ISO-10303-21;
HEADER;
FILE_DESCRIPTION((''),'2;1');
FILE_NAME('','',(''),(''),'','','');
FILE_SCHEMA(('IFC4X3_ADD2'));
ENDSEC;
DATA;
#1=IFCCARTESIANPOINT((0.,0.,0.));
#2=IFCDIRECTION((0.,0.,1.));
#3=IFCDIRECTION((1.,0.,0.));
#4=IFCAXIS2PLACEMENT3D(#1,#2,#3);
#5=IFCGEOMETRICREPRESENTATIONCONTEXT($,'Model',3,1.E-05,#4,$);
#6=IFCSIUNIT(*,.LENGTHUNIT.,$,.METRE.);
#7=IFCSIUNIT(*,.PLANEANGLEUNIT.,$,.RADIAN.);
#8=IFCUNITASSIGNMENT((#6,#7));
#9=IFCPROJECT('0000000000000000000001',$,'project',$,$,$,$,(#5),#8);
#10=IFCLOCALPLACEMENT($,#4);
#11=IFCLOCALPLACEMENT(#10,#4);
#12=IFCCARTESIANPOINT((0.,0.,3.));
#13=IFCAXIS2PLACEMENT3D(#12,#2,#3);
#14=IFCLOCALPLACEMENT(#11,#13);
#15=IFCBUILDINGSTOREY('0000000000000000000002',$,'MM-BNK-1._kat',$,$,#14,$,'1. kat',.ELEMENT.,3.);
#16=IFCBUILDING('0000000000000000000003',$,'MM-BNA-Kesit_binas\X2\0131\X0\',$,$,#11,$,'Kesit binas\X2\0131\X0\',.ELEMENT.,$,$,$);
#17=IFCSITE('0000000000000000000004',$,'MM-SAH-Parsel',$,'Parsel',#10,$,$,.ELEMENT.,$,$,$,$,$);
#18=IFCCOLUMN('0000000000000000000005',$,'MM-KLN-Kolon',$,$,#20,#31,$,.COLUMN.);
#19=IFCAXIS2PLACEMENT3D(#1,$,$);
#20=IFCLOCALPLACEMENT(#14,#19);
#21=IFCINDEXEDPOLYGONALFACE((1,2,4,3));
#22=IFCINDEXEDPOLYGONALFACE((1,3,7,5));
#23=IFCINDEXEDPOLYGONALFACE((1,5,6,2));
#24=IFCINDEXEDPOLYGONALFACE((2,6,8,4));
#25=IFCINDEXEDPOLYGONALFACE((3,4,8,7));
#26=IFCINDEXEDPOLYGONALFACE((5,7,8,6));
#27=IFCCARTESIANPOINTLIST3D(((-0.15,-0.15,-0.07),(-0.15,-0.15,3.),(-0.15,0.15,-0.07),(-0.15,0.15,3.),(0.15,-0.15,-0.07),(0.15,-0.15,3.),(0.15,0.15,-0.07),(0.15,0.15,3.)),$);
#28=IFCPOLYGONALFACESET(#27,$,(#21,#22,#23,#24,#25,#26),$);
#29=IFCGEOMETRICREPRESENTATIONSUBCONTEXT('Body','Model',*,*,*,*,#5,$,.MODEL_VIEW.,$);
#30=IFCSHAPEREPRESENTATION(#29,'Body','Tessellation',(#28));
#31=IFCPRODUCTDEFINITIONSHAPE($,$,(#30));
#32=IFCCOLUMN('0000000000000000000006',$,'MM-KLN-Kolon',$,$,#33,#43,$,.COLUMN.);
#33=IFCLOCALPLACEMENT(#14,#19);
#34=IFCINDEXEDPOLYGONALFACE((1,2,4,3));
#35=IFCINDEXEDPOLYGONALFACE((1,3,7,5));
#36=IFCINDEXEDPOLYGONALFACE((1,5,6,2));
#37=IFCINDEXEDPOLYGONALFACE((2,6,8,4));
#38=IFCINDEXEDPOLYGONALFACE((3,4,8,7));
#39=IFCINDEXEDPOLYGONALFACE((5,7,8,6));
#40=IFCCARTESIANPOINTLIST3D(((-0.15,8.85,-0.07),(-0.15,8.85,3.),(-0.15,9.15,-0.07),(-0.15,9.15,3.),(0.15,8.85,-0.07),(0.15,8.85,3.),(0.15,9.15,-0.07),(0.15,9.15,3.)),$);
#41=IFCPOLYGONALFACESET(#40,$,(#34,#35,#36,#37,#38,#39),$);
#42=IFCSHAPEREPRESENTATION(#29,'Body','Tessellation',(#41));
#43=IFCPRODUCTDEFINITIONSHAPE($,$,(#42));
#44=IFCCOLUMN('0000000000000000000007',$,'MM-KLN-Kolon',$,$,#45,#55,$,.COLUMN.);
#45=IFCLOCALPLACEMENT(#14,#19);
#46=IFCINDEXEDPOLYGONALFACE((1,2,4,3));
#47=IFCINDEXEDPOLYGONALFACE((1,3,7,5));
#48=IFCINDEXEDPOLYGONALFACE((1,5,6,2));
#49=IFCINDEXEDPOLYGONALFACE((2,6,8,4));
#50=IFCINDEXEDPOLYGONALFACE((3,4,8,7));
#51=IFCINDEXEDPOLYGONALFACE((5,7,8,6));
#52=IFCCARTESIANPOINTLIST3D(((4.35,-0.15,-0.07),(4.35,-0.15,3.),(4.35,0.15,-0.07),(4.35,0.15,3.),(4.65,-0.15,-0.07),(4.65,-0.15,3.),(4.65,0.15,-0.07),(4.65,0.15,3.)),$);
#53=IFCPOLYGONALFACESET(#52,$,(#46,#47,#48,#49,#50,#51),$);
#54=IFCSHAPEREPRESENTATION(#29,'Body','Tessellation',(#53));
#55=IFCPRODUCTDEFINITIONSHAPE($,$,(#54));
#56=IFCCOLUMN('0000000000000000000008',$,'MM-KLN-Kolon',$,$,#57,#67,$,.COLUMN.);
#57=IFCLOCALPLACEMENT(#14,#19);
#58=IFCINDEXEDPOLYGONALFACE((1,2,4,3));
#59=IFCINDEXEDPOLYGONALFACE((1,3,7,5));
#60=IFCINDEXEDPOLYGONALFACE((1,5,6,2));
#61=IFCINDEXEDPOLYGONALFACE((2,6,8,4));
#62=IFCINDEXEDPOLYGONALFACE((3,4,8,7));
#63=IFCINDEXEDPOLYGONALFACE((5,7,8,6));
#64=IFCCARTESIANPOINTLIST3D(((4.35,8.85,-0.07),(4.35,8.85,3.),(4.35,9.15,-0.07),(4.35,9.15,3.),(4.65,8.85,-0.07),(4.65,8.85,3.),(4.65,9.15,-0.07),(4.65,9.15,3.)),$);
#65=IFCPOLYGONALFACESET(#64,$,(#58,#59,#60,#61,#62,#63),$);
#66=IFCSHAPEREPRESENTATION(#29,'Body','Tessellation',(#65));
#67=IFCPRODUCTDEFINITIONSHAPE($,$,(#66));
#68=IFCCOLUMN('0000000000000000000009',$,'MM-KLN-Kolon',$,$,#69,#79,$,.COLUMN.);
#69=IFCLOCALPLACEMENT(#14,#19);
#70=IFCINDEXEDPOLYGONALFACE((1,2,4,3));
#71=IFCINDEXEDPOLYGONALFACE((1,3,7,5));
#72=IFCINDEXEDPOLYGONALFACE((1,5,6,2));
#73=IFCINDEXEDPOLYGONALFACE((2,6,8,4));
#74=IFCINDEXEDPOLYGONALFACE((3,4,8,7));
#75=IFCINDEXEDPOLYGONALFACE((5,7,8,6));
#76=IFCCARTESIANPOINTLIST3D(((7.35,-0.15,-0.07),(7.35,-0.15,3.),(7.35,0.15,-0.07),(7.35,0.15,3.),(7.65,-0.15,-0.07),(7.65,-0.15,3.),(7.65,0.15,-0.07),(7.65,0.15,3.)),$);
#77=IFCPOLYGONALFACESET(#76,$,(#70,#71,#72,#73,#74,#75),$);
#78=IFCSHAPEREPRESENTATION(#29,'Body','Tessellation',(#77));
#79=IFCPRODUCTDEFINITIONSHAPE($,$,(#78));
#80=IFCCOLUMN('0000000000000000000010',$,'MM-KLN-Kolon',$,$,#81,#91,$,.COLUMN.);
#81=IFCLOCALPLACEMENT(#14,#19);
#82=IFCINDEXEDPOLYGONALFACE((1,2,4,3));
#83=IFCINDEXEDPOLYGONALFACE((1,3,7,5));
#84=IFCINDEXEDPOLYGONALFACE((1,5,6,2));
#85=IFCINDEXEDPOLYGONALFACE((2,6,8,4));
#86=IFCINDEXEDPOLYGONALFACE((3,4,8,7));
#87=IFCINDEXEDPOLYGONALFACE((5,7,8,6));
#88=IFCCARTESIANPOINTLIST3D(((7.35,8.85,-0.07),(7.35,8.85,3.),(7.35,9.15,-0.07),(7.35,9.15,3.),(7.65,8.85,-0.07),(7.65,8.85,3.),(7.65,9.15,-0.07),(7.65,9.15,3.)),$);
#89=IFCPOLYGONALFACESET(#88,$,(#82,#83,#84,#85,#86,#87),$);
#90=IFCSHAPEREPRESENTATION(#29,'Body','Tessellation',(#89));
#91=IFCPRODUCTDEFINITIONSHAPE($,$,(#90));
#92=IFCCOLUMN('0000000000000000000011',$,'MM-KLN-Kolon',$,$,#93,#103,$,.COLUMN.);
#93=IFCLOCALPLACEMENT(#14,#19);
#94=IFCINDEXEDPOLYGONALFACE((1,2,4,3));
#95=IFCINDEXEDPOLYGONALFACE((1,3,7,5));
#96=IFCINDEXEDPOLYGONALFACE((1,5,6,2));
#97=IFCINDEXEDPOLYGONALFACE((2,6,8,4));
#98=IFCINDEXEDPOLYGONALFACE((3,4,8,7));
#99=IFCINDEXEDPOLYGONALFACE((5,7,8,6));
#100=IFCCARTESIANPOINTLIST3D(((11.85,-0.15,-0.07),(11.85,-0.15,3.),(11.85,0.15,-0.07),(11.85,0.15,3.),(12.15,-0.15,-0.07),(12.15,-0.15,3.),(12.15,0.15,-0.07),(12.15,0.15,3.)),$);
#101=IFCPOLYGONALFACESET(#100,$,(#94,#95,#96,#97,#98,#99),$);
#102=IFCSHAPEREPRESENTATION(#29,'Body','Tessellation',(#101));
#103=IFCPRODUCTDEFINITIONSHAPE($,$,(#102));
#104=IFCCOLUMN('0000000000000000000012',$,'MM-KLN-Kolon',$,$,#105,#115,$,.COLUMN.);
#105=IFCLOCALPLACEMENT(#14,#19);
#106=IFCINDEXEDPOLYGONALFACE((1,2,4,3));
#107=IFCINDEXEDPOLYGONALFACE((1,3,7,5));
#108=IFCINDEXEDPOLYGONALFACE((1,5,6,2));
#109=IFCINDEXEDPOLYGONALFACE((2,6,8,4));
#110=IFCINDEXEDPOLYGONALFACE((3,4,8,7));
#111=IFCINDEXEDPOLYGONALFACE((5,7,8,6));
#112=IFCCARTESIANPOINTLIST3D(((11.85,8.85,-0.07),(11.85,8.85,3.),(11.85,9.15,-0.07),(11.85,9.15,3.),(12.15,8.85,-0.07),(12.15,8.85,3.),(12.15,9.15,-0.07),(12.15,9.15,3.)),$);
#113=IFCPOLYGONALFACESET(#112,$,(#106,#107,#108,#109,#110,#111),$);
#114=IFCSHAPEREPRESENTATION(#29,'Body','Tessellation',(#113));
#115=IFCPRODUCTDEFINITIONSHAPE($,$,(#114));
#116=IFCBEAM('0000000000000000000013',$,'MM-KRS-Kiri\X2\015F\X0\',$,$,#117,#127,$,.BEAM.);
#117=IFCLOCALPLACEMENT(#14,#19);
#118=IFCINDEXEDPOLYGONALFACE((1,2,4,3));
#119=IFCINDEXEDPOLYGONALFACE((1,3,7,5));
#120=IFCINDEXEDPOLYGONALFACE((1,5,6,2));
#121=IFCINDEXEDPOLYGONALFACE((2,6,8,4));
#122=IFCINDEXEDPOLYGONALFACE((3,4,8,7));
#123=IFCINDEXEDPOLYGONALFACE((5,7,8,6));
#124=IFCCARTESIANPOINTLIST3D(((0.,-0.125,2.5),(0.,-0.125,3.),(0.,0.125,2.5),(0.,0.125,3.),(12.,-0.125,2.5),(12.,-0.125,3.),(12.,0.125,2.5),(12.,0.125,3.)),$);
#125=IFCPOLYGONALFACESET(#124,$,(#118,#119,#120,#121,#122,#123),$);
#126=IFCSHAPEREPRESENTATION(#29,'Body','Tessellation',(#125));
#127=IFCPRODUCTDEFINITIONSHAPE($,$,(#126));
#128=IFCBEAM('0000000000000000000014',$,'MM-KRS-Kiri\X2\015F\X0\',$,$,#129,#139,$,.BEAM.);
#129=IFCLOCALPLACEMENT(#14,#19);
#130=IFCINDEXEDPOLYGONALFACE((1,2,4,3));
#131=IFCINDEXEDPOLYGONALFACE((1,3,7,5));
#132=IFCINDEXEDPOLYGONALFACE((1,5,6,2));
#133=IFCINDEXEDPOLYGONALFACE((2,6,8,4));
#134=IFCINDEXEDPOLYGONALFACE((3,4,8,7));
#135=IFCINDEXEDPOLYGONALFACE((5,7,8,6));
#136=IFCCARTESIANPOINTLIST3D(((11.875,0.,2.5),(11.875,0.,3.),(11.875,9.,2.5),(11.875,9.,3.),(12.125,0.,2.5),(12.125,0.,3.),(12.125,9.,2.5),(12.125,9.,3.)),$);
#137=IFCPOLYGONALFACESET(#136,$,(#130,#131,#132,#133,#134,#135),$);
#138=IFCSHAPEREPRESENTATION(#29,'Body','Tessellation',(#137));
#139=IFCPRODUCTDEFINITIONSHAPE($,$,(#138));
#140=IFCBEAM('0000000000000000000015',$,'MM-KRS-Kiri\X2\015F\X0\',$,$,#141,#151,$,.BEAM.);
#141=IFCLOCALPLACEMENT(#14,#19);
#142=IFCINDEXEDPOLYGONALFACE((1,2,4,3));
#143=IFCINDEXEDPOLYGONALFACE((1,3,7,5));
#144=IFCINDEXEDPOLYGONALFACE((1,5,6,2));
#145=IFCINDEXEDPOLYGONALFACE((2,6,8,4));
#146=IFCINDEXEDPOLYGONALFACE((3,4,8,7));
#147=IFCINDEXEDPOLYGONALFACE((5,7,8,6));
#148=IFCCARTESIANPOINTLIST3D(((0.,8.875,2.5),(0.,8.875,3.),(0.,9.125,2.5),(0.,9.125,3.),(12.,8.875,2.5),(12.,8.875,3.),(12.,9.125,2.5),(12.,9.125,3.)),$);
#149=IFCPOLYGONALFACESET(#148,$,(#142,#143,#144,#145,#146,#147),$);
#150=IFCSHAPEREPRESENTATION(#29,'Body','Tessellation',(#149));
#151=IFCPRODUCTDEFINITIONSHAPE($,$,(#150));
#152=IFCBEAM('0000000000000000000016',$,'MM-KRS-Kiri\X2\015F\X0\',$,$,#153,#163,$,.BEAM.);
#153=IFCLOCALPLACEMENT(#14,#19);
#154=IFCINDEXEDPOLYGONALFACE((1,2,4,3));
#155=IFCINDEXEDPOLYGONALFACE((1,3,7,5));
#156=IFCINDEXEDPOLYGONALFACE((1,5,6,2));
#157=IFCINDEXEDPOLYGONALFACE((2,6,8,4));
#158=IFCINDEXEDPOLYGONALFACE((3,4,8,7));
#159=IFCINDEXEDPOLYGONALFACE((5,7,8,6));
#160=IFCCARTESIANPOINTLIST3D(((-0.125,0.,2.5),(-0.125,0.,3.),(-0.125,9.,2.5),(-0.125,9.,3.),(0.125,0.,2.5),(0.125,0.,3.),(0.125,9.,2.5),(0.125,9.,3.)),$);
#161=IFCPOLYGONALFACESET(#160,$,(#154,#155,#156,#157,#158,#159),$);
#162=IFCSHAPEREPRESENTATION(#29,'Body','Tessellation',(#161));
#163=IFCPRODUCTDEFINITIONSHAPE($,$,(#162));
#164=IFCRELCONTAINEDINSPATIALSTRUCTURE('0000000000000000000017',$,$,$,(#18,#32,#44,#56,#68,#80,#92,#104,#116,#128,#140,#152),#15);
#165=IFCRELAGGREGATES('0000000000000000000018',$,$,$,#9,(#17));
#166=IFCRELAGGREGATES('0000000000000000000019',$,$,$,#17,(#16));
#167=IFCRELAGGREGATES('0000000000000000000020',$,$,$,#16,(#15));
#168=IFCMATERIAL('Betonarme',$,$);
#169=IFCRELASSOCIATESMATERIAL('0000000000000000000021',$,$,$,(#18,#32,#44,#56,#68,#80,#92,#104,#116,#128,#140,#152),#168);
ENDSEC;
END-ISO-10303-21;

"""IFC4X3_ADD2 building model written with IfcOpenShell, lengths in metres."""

from ifc_helpers import new_model, si_unit, frame, origin_with_axes, place, context, subcontext, project, spatial, polyline, outline, extrude, material, element, save


model = new_model("IFC4X3_ADD2")

# Units and contexts
model_context = context("Model", 3, precision=1e-05, world=origin_with_axes())
body_context = subcontext(model_context, "Body", "Model", "MODEL_VIEW")
ifc_project = project(units=[si_unit("LENGTHUNIT", "METRE"), si_unit("PLANEANGLEUNIT", "RADIAN")], contexts=[model_context])

# Site, building, storey
site_placement = place(None, origin_with_axes())
site = spatial("IfcSite", under=ifc_project, at=site_placement, Name="MM-SAH-Parsel", ObjectType="Parsel", CompositionType="ELEMENT")
building_placement = place(site_placement, origin_with_axes())
building = spatial("IfcBuilding", under=site, at=building_placement, Name="MM-BNA-Kesit_binası", LongName="Kesit binası", CompositionType="ELEMENT")
storey_placement = place(building_placement, frame((0.0, 0.0, 3.0), z_axis=(0.0, 0.0, 1.0), x_axis=(1.0, 0.0, 0.0)))
storey = spatial("IfcBuildingStorey", under=building, at=storey_placement, Name="MM-BNK-1._kat", LongName="1. kat", CompositionType="ELEMENT", Elevation=3.0)

# Columns
ifc_material_1 = material(Name="Betonarme")
column_1_placement = place(storey_placement, origin_with_axes())
element("IfcColumn", 1, at=column_1_placement, inside=storey, material=ifc_material_1, Name="MM-KLN-Kolon", PredefinedType="COLUMN", context=body_context, shape_type="SweptSolid", body=[
    extrude(outline(polyline([(-0.15, -0.15), (0.15, -0.15), (0.15, 0.15), (-0.15, 0.15), (-0.15, -0.15)])), frame((0.0, 0.0, -0.07)), (0.0, 0.0, 1.0), 3.07),
])
column_2_placement = place(storey_placement, origin_with_axes())
element("IfcColumn", 2, at=column_2_placement, inside=storey, material=ifc_material_1, Name="MM-KLN-Kolon", PredefinedType="COLUMN", context=body_context, shape_type="SweptSolid", body=[
    extrude(outline(polyline([(-0.15, 8.85), (0.15, 8.85), (0.15, 9.15), (-0.15, 9.15), (-0.15, 8.85)])), frame((0.0, 0.0, -0.07)), (0.0, 0.0, 1.0), 3.07),
])
column_3_placement = place(storey_placement, origin_with_axes())
element("IfcColumn", 3, at=column_3_placement, inside=storey, material=ifc_material_1, Name="MM-KLN-Kolon", PredefinedType="COLUMN", context=body_context, shape_type="SweptSolid", body=[
    extrude(outline(polyline([(4.35, -0.15), (4.65, -0.15), (4.65, 0.15), (4.35, 0.15), (4.35, -0.15)])), frame((0.0, 0.0, -0.07)), (0.0, 0.0, 1.0), 3.07),
])
column_4_placement = place(storey_placement, origin_with_axes())
element("IfcColumn", 4, at=column_4_placement, inside=storey, material=ifc_material_1, Name="MM-KLN-Kolon", PredefinedType="COLUMN", context=body_context, shape_type="SweptSolid", body=[
    extrude(outline(polyline([(4.35, 8.85), (4.65, 8.85), (4.65, 9.15), (4.35, 9.15), (4.35, 8.85)])), frame((0.0, 0.0, -0.07)), (0.0, 0.0, 1.0), 3.07),
])
column_5_placement = place(storey_placement, origin_with_axes())
element("IfcColumn", 5, at=column_5_placement, inside=storey, material=ifc_material_1, Name="MM-KLN-Kolon", PredefinedType="COLUMN", context=body_context, shape_type="SweptSolid", body=[
    extrude(outline(polyline([(7.35, -0.15), (7.65, -0.15), (7.65, 0.15), (7.35, 0.15), (7.35, -0.15)])), frame((0.0, 0.0, -0.07)), (0.0, 0.0, 1.0), 3.07),
])
column_6_placement = place(storey_placement, origin_with_axes())
element("IfcColumn", 6, at=column_6_placement, inside=storey, material=ifc_material_1, Name="MM-KLN-Kolon", PredefinedType="COLUMN", context=body_context, shape_type="SweptSolid", body=[
    extrude(outline(polyline([(7.35, 8.85), (7.65, 8.85), (7.65, 9.15), (7.35, 9.15), (7.35, 8.85)])), frame((0.0, 0.0, -0.07)), (0.0, 0.0, 1.0), 3.07),
])
column_7_placement = place(storey_placement, origin_with_axes())
element("IfcColumn", 7, at=column_7_placement, inside=storey, material=ifc_material_1, Name="MM-KLN-Kolon", PredefinedType="COLUMN", context=body_context, shape_type="SweptSolid", body=[
    extrude(outline(polyline([(11.85, -0.15), (12.15, -0.15), (12.15, 0.15), (11.85, 0.15), (11.85, -0.15)])), frame((0.0, 0.0, -0.07)), (0.0, 0.0, 1.0), 3.07),
])
column_8_placement = place(storey_placement, origin_with_axes())
element("IfcColumn", 8, at=column_8_placement, inside=storey, material=ifc_material_1, Name="MM-KLN-Kolon", PredefinedType="COLUMN", context=body_context, shape_type="SweptSolid", body=[
    extrude(outline(polyline([(11.85, 8.85), (12.15, 8.85), (12.15, 9.15), (11.85, 9.15), (11.85, 8.85)])), frame((0.0, 0.0, -0.07)), (0.0, 0.0, 1.0), 3.07),
])

# Beams
beam_1_placement = place(storey_placement, origin_with_axes())
element("IfcBeam", 9, at=beam_1_placement, inside=storey, material=ifc_material_1, Name="MM-KRS-Kiriş", PredefinedType="BEAM", context=body_context, shape_type="SweptSolid", body=[
    extrude(outline(polyline([(0.0, 0.125), (12.0, 0.125), (12.0, -0.125), (0.0, -0.125), (0.0, 0.125)])), frame((0.0, 0.0, 2.5)), (0.0, 0.0, 1.0), 0.5),
])
beam_2_placement = place(storey_placement, origin_with_axes())
element("IfcBeam", 10, at=beam_2_placement, inside=storey, material=ifc_material_1, Name="MM-KRS-Kiriş", PredefinedType="BEAM", context=body_context, shape_type="SweptSolid", body=[
    extrude(outline(polyline([(11.875, 0.0), (11.875, 9.0), (12.125, 9.0), (12.125, 0.0), (11.875, 0.0)])), frame((0.0, 0.0, 2.5)), (0.0, 0.0, 1.0), 0.5),
])
beam_3_placement = place(storey_placement, origin_with_axes())
element("IfcBeam", 11, at=beam_3_placement, inside=storey, material=ifc_material_1, Name="MM-KRS-Kiriş", PredefinedType="BEAM", context=body_context, shape_type="SweptSolid", body=[
    extrude(outline(polyline([(12.0, 8.875), (0.0, 8.875), (0.0, 9.125), (12.0, 9.125), (12.0, 8.875)])), frame((0.0, 0.0, 2.5)), (0.0, 0.0, 1.0), 0.5),
])
beam_4_placement = place(storey_placement, origin_with_axes())
element("IfcBeam", 12, at=beam_4_placement, inside=storey, material=ifc_material_1, Name="MM-KRS-Kiriş", PredefinedType="BEAM", context=body_context, shape_type="SweptSolid", body=[
    extrude(outline(polyline([(0.125, 9.0), (0.125, 0.0), (-0.125, 0.0), (-0.125, 9.0), (0.125, 9.0)])), frame((0.0, 0.0, 2.5)), (0.0, 0.0, 1.0), 0.5),
])

save(model, "model.ifc")
